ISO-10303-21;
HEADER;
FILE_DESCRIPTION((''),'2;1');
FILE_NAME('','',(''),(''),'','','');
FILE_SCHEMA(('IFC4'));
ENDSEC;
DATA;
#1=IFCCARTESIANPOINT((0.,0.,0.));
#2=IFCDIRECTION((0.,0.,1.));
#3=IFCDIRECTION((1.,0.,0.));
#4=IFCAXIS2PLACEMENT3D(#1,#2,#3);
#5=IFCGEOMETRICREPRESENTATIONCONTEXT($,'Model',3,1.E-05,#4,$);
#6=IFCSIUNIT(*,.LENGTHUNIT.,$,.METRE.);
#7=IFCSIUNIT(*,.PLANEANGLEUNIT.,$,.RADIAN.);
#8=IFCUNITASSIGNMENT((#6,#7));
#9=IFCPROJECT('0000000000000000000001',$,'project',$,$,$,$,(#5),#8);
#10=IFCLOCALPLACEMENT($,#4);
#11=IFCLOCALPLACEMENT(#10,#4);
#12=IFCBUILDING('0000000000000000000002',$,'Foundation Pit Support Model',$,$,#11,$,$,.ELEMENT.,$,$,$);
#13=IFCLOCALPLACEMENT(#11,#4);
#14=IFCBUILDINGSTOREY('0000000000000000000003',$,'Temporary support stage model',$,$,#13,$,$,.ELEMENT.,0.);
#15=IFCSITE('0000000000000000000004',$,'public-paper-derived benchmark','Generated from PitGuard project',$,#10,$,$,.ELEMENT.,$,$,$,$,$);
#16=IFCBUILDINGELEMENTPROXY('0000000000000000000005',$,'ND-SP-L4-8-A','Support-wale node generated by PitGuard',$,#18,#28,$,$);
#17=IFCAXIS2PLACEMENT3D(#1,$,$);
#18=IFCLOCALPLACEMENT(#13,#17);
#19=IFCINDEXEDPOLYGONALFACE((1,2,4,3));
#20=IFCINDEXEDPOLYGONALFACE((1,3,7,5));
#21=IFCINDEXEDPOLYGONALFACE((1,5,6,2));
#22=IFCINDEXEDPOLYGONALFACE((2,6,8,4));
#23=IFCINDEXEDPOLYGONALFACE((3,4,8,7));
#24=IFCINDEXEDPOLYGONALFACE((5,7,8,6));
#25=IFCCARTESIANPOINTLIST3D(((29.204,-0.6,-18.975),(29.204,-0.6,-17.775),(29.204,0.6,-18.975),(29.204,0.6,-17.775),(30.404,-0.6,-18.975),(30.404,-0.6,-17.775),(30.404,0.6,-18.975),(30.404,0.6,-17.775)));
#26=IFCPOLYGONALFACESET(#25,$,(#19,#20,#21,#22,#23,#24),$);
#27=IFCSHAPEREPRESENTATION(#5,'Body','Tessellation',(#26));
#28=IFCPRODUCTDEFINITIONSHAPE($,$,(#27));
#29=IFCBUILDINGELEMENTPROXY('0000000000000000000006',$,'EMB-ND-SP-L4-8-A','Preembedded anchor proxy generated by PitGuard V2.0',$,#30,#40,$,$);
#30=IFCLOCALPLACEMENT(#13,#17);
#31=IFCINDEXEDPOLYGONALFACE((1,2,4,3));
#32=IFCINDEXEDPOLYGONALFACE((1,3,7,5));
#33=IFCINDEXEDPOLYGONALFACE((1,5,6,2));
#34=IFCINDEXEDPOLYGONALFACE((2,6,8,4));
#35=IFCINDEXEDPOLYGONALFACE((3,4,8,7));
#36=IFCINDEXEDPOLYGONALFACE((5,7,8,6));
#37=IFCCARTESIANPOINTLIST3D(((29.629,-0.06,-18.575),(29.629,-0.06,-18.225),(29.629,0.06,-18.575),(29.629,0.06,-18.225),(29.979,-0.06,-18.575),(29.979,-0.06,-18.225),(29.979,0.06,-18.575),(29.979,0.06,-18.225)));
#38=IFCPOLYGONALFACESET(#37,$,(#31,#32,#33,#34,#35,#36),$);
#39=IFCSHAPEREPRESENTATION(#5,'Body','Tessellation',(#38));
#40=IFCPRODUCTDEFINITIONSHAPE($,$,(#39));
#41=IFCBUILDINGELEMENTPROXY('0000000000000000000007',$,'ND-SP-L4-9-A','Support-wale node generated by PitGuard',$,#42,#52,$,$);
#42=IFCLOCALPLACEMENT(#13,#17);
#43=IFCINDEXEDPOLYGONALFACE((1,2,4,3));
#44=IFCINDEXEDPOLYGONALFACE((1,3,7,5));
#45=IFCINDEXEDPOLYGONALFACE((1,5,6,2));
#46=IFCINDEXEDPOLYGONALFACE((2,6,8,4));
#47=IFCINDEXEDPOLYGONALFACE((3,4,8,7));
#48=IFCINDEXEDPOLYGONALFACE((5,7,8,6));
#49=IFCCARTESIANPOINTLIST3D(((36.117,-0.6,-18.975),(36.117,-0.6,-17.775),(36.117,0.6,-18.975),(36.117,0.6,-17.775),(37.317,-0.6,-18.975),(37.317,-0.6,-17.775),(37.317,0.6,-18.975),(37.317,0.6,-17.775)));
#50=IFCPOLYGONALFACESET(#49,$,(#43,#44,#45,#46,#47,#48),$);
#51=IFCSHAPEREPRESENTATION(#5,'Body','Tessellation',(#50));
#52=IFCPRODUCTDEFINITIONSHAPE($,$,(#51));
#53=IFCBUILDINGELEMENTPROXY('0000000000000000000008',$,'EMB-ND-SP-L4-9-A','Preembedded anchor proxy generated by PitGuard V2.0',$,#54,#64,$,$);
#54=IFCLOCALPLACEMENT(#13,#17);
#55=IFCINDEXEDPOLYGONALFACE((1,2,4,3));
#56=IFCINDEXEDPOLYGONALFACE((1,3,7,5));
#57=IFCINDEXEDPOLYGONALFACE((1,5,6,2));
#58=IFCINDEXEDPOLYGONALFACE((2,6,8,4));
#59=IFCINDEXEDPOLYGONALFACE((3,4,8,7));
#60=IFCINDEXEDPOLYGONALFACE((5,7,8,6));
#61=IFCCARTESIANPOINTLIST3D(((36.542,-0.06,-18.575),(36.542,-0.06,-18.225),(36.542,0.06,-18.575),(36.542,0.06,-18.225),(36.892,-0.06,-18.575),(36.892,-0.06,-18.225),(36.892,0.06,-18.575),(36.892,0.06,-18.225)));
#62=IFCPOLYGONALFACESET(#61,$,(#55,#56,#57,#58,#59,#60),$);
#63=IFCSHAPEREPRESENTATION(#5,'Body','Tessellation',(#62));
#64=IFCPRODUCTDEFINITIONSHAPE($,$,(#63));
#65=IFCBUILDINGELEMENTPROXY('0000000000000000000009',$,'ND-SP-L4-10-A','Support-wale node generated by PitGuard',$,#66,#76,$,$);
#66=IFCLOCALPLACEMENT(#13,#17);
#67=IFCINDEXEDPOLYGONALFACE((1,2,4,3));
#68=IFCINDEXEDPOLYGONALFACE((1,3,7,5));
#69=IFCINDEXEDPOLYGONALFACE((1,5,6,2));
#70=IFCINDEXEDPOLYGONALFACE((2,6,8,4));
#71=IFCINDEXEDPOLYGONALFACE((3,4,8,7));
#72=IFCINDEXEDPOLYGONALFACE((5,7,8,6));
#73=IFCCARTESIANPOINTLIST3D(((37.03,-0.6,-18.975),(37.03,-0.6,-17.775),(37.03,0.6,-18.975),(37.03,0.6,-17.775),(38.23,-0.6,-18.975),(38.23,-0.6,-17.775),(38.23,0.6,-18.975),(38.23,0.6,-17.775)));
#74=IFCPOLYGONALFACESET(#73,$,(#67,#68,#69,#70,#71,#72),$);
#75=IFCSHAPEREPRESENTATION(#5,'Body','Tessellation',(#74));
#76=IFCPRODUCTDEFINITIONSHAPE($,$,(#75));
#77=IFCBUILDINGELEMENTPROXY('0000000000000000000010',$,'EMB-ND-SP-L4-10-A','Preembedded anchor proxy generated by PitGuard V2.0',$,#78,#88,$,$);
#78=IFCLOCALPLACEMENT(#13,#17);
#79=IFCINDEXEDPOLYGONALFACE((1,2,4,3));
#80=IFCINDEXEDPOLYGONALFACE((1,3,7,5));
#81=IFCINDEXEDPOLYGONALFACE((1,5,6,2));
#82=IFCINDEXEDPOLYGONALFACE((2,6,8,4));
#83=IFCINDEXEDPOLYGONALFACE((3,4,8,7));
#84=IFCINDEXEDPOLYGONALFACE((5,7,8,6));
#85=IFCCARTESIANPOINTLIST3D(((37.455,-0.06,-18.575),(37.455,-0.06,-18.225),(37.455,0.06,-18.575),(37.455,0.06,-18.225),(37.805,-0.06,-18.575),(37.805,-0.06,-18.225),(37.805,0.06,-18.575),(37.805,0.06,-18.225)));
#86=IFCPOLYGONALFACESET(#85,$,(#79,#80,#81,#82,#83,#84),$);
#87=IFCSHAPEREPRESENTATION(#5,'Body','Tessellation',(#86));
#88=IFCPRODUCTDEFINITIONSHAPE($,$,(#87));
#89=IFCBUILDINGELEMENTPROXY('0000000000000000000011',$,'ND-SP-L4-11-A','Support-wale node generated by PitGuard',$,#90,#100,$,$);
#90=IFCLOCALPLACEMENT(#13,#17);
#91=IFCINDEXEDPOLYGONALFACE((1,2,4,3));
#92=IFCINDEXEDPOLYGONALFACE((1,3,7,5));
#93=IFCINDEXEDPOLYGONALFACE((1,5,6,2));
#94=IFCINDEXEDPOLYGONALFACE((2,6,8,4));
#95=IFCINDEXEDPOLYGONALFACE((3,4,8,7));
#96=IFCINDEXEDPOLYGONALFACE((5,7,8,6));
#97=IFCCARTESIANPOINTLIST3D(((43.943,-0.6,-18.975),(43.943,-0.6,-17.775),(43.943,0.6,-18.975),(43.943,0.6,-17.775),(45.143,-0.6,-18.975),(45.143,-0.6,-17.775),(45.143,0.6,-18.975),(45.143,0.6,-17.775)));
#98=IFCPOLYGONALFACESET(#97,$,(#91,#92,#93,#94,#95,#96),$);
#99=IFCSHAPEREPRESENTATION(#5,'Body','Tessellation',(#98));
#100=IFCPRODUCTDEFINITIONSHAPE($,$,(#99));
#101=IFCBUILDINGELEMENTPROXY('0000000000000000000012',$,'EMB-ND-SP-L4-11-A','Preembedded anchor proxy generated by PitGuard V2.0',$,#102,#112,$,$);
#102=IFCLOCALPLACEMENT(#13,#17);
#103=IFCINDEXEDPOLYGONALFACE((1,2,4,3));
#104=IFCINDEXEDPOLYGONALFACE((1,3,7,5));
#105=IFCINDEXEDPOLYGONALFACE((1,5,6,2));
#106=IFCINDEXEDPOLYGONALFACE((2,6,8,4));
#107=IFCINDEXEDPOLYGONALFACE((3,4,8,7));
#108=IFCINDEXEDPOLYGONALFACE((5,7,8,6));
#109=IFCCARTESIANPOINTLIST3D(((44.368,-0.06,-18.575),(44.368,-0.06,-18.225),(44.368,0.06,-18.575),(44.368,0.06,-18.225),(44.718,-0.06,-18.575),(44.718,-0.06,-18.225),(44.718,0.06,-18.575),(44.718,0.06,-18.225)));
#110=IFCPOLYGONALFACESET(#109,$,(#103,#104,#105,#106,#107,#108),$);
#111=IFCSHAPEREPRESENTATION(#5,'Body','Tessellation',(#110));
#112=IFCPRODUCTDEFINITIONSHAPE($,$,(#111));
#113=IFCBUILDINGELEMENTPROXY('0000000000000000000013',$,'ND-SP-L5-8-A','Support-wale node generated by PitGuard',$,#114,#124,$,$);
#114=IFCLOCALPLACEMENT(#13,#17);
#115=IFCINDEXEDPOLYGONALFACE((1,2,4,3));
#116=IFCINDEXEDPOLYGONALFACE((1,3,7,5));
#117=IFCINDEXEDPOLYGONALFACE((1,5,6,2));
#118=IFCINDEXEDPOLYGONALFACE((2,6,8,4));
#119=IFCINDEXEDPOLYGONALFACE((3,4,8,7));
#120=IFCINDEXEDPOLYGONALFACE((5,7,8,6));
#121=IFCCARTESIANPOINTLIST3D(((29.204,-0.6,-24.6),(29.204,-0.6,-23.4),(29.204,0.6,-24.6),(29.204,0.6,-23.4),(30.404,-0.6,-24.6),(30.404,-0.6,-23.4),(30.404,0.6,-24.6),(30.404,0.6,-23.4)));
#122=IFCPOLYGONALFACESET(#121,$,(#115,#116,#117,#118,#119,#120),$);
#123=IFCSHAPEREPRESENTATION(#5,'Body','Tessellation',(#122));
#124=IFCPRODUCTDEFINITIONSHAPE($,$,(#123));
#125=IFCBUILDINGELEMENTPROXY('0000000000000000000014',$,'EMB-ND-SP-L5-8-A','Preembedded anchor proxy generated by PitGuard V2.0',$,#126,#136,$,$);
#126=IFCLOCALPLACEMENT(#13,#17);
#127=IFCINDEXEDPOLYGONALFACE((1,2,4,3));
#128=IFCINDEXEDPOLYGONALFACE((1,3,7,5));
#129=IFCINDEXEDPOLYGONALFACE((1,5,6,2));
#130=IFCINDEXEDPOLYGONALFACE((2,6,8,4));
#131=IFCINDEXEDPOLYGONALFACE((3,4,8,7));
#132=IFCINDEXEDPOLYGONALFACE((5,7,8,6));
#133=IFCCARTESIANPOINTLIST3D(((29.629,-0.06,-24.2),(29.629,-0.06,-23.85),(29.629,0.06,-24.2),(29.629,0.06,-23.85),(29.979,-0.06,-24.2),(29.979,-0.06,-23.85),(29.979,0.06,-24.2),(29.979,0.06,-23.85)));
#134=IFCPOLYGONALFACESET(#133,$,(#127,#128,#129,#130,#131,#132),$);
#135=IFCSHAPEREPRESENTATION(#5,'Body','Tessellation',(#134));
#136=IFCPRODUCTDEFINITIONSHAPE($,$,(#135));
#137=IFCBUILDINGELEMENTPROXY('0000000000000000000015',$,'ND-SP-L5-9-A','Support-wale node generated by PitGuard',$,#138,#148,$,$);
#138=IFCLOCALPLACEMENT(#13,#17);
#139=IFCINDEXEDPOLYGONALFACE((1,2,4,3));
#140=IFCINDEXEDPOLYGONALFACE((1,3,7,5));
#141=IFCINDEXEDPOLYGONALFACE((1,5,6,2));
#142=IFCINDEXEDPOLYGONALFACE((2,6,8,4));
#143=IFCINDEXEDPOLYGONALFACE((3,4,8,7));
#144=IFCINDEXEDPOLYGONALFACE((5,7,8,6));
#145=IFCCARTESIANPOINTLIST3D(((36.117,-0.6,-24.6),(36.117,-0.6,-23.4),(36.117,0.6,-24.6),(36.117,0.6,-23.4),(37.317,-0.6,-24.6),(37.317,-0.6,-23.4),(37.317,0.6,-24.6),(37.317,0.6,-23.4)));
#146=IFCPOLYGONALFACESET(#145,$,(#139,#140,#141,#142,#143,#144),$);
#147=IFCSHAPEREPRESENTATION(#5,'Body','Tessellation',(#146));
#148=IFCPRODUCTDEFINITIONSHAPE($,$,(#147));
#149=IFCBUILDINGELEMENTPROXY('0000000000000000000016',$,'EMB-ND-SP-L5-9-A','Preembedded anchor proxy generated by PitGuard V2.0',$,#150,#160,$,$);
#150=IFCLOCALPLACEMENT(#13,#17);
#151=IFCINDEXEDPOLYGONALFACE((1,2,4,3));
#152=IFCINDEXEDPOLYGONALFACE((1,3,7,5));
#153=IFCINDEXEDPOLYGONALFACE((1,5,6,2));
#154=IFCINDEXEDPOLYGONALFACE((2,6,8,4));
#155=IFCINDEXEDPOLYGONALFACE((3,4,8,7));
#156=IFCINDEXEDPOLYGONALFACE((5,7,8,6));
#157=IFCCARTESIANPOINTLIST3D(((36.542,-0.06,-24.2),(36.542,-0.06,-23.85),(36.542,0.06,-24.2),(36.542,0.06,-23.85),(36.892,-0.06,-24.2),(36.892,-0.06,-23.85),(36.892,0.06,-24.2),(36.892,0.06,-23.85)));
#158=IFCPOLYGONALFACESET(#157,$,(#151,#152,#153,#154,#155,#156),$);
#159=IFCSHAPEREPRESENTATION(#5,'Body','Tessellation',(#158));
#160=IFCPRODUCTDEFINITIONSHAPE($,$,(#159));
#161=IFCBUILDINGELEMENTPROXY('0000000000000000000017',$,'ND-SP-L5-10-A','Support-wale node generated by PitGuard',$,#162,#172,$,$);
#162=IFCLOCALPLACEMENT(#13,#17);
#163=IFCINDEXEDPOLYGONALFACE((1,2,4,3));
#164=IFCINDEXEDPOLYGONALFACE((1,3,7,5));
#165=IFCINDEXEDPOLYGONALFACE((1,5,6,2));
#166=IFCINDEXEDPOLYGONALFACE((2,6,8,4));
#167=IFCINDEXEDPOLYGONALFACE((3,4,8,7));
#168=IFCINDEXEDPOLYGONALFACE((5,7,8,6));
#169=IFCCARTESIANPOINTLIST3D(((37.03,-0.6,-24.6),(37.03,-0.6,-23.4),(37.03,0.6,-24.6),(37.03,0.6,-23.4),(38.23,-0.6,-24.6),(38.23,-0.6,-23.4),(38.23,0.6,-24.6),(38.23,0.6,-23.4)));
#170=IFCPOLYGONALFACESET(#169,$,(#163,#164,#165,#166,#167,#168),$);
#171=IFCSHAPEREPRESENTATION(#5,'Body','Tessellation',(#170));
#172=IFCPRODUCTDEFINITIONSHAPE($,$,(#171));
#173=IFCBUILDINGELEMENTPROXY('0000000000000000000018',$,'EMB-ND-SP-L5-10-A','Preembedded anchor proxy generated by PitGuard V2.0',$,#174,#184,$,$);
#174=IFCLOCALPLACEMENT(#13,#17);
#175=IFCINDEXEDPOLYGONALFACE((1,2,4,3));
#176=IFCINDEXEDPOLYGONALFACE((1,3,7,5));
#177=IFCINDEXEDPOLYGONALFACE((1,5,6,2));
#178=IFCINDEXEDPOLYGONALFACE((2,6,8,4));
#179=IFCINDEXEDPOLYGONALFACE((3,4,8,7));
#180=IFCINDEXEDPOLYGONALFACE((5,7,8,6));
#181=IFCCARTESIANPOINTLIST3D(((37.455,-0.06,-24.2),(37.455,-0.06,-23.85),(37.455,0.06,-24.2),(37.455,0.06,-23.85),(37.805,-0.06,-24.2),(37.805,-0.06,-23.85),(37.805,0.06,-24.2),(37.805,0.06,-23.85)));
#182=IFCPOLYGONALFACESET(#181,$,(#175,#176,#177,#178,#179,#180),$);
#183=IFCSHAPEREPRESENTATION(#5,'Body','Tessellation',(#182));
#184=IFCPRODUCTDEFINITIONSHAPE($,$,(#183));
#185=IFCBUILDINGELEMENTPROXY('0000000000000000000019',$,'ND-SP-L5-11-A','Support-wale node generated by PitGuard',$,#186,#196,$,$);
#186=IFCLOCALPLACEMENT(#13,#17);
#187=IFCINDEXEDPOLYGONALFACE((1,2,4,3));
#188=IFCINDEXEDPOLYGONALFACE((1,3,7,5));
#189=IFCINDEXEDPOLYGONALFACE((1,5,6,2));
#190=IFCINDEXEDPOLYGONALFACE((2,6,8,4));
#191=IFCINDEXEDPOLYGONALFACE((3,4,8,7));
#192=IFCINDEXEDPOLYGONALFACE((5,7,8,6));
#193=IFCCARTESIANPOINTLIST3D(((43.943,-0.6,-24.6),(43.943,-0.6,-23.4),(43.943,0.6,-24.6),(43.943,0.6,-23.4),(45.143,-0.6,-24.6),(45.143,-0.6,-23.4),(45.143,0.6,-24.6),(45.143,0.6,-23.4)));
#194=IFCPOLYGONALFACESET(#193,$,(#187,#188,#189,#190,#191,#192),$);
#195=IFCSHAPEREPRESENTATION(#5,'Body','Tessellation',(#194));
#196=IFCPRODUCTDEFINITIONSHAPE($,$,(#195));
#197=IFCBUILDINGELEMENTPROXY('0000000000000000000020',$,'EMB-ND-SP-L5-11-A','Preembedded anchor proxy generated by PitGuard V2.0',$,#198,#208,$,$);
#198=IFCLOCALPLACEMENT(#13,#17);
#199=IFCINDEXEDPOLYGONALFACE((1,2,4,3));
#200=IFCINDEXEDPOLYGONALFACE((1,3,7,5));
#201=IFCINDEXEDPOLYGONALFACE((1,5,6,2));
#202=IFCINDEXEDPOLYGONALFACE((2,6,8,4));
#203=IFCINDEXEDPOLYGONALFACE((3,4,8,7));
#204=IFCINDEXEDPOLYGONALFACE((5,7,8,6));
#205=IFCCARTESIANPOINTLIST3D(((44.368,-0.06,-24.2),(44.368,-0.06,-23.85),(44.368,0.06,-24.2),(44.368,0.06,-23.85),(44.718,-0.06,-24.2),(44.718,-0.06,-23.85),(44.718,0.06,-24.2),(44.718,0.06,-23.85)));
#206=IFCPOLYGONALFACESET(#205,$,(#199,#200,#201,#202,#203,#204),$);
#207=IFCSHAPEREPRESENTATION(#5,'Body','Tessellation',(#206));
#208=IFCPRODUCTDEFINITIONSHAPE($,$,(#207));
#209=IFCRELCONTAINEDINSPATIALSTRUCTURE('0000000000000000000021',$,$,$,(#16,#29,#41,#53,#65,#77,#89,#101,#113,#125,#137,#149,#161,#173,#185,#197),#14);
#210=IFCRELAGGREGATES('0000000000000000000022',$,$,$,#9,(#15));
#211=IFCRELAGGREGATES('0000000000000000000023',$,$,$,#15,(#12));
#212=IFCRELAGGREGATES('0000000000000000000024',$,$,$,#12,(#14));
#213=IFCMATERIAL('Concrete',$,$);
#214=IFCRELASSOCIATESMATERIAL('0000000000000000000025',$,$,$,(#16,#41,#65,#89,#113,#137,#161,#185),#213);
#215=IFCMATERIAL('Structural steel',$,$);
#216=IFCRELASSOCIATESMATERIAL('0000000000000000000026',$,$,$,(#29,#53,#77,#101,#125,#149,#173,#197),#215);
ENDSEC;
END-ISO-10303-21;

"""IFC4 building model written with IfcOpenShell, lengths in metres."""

from ifc_helpers import new_model, si_unit, frame, origin_with_axes, origin_2d, place, context, project, spatial, rectangle, extrude, material, element, save


model = new_model("IFC4")

# Units and contexts
model_context = context("Model", 3, precision=1e-05, world=origin_with_axes())
ifc_project = project(units=[si_unit("LENGTHUNIT", "METRE"), si_unit("PLANEANGLEUNIT", "RADIAN")], contexts=[model_context])

# Site, building, storey
site_placement = place(None, origin_with_axes())
site = spatial("IfcSite", under=ifc_project, at=site_placement, Name="public-paper-derived benchmark", Description="Generated from PitGuard project", CompositionType="ELEMENT")
building_placement = place(site_placement, origin_with_axes())
building = spatial("IfcBuilding", under=site, at=building_placement, Name="Foundation Pit Support Model", CompositionType="ELEMENT")
storey_placement = place(building_placement, origin_with_axes())
storey = spatial("IfcBuildingStorey", under=building, at=storey_placement, Name="Temporary support stage model", CompositionType="ELEMENT", Elevation=0.0)

# Shared definitions
ifc_material_1 = material(Name="Structural steel")

# Shared definitions
ifc_material_2 = material(Name="Concrete")

# Building element proxies
for number, where, z_axis, x_axis, name in (
    (1, (29.804, 0.0, -18.975), (0.0, 0.0, 1.0), (1.0, 0.0, 0.0), "ND-SP-L4-8-A"),
):
    element("IfcBuildingElementProxy", number, at=place(storey_placement, frame(where, z_axis=z_axis, x_axis=x_axis)), inside=storey, material=ifc_material_2, Name=name, Description="Support-wale node generated by PitGuard", context=model_context, shape_type="SweptSolid", body=[
        extrude(rectangle(XDim=1.2, YDim=1.2, at=origin_2d()), origin_with_axes(), (0.0, 0.0, 1.0), 1.2),
    ])
proxy_1_placement = place(storey_placement, frame((29.804, 0.0, -18.575), z_axis=(0.0, 0.0, 1.0), x_axis=(1.0, 0.0, 0.0)))
element("IfcBuildingElementProxy", 2, at=proxy_1_placement, inside=storey, material=ifc_material_1, Name="EMB-ND-SP-L4-8-A", Description="Preembedded anchor proxy generated by PitGuard V2.0", context=model_context, shape_type="SweptSolid", body=[
    extrude(rectangle(XDim=0.35, YDim=0.12, at=origin_2d()), origin_with_axes(), (0.0, 0.0, 1.0), 0.35),
])
proxy_2_placement = place(storey_placement, frame((36.717, 0.0, -18.975), z_axis=(0.0, 0.0, 1.0), x_axis=(1.0, 0.0, 0.0)))
element("IfcBuildingElementProxy", 3, at=proxy_2_placement, inside=storey, material=ifc_material_2, Name="ND-SP-L4-9-A", Description="Support-wale node generated by PitGuard", context=model_context, shape_type="SweptSolid", body=[
    extrude(rectangle(XDim=1.2, YDim=1.2, at=origin_2d()), origin_with_axes(), (0.0, 0.0, 1.0), 1.2),
])
proxy_3_placement = place(storey_placement, frame((36.717, 0.0, -18.575), z_axis=(0.0, 0.0, 1.0), x_axis=(1.0, 0.0, 0.0)))
element("IfcBuildingElementProxy", 4, at=proxy_3_placement, inside=storey, material=ifc_material_1, Name="EMB-ND-SP-L4-9-A", Description="Preembedded anchor proxy generated by PitGuard V2.0", context=model_context, shape_type="SweptSolid", body=[
    extrude(rectangle(XDim=0.35, YDim=0.12, at=origin_2d()), origin_with_axes(), (0.0, 0.0, 1.0), 0.35),
])
proxy_4_placement = place(storey_placement, frame((37.63, 0.0, -18.975), z_axis=(0.0, 0.0, 1.0), x_axis=(1.0, 0.0, 0.0)))
element("IfcBuildingElementProxy", 5, at=proxy_4_placement, inside=storey, material=ifc_material_2, Name="ND-SP-L4-10-A", Description="Support-wale node generated by PitGuard", context=model_context, shape_type="SweptSolid", body=[
    extrude(rectangle(XDim=1.2, YDim=1.2, at=origin_2d()), origin_with_axes(), (0.0, 0.0, 1.0), 1.2),
])
proxy_5_placement = place(storey_placement, frame((37.63, 0.0, -18.575), z_axis=(0.0, 0.0, 1.0), x_axis=(1.0, 0.0, 0.0)))
element("IfcBuildingElementProxy", 6, at=proxy_5_placement, inside=storey, material=ifc_material_1, Name="EMB-ND-SP-L4-10-A", Description="Preembedded anchor proxy generated by PitGuard V2.0", context=model_context, shape_type="SweptSolid", body=[
    extrude(rectangle(XDim=0.35, YDim=0.12, at=origin_2d()), origin_with_axes(), (0.0, 0.0, 1.0), 0.35),
])
proxy_6_placement = place(storey_placement, frame((44.543, 0.0, -18.975), z_axis=(0.0, 0.0, 1.0), x_axis=(1.0, 0.0, 0.0)))
element("IfcBuildingElementProxy", 7, at=proxy_6_placement, inside=storey, material=ifc_material_2, Name="ND-SP-L4-11-A", Description="Support-wale node generated by PitGuard", context=model_context, shape_type="SweptSolid", body=[
    extrude(rectangle(XDim=1.2, YDim=1.2, at=origin_2d()), origin_with_axes(), (0.0, 0.0, 1.0), 1.2),
])
proxy_7_placement = place(storey_placement, frame((44.543, 0.0, -18.575), z_axis=(0.0, 0.0, 1.0), x_axis=(1.0, 0.0, 0.0)))
element("IfcBuildingElementProxy", 8, at=proxy_7_placement, inside=storey, material=ifc_material_1, Name="EMB-ND-SP-L4-11-A", Description="Preembedded anchor proxy generated by PitGuard V2.0", context=model_context, shape_type="SweptSolid", body=[
    extrude(rectangle(XDim=0.35, YDim=0.12, at=origin_2d()), origin_with_axes(), (0.0, 0.0, 1.0), 0.35),
])
proxy_8_placement = place(storey_placement, frame((29.804, 0.0, -24.6), z_axis=(0.0, 0.0, 1.0), x_axis=(1.0, 0.0, 0.0)))
element("IfcBuildingElementProxy", 9, at=proxy_8_placement, inside=storey, material=ifc_material_2, Name="ND-SP-L5-8-A", Description="Support-wale node generated by PitGuard", context=model_context, shape_type="SweptSolid", body=[
    extrude(rectangle(XDim=1.2, YDim=1.2, at=origin_2d()), origin_with_axes(), (0.0, 0.0, 1.0), 1.2),
])
proxy_9_placement = place(storey_placement, frame((29.804, 0.0, -24.2), z_axis=(0.0, 0.0, 1.0), x_axis=(1.0, 0.0, 0.0)))
element("IfcBuildingElementProxy", 10, at=proxy_9_placement, inside=storey, material=ifc_material_1, Name="EMB-ND-SP-L5-8-A", Description="Preembedded anchor proxy generated by PitGuard V2.0", context=model_context, shape_type="SweptSolid", body=[
    extrude(rectangle(XDim=0.35, YDim=0.12, at=origin_2d()), origin_with_axes(), (0.0, 0.0, 1.0), 0.35),
])
proxy_10_placement = place(storey_placement, frame((36.717, 0.0, -24.6), z_axis=(0.0, 0.0, 1.0), x_axis=(1.0, 0.0, 0.0)))
element("IfcBuildingElementProxy", 11, at=proxy_10_placement, inside=storey, material=ifc_material_2, Name="ND-SP-L5-9-A", Description="Support-wale node generated by PitGuard", context=model_context, shape_type="SweptSolid", body=[
    extrude(rectangle(XDim=1.2, YDim=1.2, at=origin_2d()), origin_with_axes(), (0.0, 0.0, 1.0), 1.2),
])
proxy_11_placement = place(storey_placement, frame((36.717, 0.0, -24.2), z_axis=(0.0, 0.0, 1.0), x_axis=(1.0, 0.0, 0.0)))
element("IfcBuildingElementProxy", 12, at=proxy_11_placement, inside=storey, material=ifc_material_1, Name="EMB-ND-SP-L5-9-A", Description="Preembedded anchor proxy generated by PitGuard V2.0", context=model_context, shape_type="SweptSolid", body=[
    extrude(rectangle(XDim=0.35, YDim=0.12, at=origin_2d()), origin_with_axes(), (0.0, 0.0, 1.0), 0.35),
])
proxy_12_placement = place(storey_placement, frame((37.63, 0.0, -24.6), z_axis=(0.0, 0.0, 1.0), x_axis=(1.0, 0.0, 0.0)))
element("IfcBuildingElementProxy", 13, at=proxy_12_placement, inside=storey, material=ifc_material_2, Name="ND-SP-L5-10-A", Description="Support-wale node generated by PitGuard", context=model_context, shape_type="SweptSolid", body=[
    extrude(rectangle(XDim=1.2, YDim=1.2, at=origin_2d()), origin_with_axes(), (0.0, 0.0, 1.0), 1.2),
])
proxy_13_placement = place(storey_placement, frame((37.63, 0.0, -24.2), z_axis=(0.0, 0.0, 1.0), x_axis=(1.0, 0.0, 0.0)))
element("IfcBuildingElementProxy", 14, at=proxy_13_placement, inside=storey, material=ifc_material_1, Name="EMB-ND-SP-L5-10-A", Description="Preembedded anchor proxy generated by PitGuard V2.0", context=model_context, shape_type="SweptSolid", body=[
    extrude(rectangle(XDim=0.35, YDim=0.12, at=origin_2d()), origin_with_axes(), (0.0, 0.0, 1.0), 0.35),
])
proxy_14_placement = place(storey_placement, frame((44.543, 0.0, -24.6), z_axis=(0.0, 0.0, 1.0), x_axis=(1.0, 0.0, 0.0)))
element("IfcBuildingElementProxy", 15, at=proxy_14_placement, inside=storey, material=ifc_material_2, Name="ND-SP-L5-11-A", Description="Support-wale node generated by PitGuard", context=model_context, shape_type="SweptSolid", body=[
    extrude(rectangle(XDim=1.2, YDim=1.2, at=origin_2d()), origin_with_axes(), (0.0, 0.0, 1.0), 1.2),
])
proxy_15_placement = place(storey_placement, frame((44.543, 0.0, -24.2), z_axis=(0.0, 0.0, 1.0), x_axis=(1.0, 0.0, 0.0)))
element("IfcBuildingElementProxy", 16, at=proxy_15_placement, inside=storey, material=ifc_material_1, Name="EMB-ND-SP-L5-11-A", Description="Preembedded anchor proxy generated by PitGuard V2.0", context=model_context, shape_type="SweptSolid", body=[
    extrude(rectangle(XDim=0.35, YDim=0.12, at=origin_2d()), origin_with_axes(), (0.0, 0.0, 1.0), 0.35),
])

save(model, "model.ifc")
